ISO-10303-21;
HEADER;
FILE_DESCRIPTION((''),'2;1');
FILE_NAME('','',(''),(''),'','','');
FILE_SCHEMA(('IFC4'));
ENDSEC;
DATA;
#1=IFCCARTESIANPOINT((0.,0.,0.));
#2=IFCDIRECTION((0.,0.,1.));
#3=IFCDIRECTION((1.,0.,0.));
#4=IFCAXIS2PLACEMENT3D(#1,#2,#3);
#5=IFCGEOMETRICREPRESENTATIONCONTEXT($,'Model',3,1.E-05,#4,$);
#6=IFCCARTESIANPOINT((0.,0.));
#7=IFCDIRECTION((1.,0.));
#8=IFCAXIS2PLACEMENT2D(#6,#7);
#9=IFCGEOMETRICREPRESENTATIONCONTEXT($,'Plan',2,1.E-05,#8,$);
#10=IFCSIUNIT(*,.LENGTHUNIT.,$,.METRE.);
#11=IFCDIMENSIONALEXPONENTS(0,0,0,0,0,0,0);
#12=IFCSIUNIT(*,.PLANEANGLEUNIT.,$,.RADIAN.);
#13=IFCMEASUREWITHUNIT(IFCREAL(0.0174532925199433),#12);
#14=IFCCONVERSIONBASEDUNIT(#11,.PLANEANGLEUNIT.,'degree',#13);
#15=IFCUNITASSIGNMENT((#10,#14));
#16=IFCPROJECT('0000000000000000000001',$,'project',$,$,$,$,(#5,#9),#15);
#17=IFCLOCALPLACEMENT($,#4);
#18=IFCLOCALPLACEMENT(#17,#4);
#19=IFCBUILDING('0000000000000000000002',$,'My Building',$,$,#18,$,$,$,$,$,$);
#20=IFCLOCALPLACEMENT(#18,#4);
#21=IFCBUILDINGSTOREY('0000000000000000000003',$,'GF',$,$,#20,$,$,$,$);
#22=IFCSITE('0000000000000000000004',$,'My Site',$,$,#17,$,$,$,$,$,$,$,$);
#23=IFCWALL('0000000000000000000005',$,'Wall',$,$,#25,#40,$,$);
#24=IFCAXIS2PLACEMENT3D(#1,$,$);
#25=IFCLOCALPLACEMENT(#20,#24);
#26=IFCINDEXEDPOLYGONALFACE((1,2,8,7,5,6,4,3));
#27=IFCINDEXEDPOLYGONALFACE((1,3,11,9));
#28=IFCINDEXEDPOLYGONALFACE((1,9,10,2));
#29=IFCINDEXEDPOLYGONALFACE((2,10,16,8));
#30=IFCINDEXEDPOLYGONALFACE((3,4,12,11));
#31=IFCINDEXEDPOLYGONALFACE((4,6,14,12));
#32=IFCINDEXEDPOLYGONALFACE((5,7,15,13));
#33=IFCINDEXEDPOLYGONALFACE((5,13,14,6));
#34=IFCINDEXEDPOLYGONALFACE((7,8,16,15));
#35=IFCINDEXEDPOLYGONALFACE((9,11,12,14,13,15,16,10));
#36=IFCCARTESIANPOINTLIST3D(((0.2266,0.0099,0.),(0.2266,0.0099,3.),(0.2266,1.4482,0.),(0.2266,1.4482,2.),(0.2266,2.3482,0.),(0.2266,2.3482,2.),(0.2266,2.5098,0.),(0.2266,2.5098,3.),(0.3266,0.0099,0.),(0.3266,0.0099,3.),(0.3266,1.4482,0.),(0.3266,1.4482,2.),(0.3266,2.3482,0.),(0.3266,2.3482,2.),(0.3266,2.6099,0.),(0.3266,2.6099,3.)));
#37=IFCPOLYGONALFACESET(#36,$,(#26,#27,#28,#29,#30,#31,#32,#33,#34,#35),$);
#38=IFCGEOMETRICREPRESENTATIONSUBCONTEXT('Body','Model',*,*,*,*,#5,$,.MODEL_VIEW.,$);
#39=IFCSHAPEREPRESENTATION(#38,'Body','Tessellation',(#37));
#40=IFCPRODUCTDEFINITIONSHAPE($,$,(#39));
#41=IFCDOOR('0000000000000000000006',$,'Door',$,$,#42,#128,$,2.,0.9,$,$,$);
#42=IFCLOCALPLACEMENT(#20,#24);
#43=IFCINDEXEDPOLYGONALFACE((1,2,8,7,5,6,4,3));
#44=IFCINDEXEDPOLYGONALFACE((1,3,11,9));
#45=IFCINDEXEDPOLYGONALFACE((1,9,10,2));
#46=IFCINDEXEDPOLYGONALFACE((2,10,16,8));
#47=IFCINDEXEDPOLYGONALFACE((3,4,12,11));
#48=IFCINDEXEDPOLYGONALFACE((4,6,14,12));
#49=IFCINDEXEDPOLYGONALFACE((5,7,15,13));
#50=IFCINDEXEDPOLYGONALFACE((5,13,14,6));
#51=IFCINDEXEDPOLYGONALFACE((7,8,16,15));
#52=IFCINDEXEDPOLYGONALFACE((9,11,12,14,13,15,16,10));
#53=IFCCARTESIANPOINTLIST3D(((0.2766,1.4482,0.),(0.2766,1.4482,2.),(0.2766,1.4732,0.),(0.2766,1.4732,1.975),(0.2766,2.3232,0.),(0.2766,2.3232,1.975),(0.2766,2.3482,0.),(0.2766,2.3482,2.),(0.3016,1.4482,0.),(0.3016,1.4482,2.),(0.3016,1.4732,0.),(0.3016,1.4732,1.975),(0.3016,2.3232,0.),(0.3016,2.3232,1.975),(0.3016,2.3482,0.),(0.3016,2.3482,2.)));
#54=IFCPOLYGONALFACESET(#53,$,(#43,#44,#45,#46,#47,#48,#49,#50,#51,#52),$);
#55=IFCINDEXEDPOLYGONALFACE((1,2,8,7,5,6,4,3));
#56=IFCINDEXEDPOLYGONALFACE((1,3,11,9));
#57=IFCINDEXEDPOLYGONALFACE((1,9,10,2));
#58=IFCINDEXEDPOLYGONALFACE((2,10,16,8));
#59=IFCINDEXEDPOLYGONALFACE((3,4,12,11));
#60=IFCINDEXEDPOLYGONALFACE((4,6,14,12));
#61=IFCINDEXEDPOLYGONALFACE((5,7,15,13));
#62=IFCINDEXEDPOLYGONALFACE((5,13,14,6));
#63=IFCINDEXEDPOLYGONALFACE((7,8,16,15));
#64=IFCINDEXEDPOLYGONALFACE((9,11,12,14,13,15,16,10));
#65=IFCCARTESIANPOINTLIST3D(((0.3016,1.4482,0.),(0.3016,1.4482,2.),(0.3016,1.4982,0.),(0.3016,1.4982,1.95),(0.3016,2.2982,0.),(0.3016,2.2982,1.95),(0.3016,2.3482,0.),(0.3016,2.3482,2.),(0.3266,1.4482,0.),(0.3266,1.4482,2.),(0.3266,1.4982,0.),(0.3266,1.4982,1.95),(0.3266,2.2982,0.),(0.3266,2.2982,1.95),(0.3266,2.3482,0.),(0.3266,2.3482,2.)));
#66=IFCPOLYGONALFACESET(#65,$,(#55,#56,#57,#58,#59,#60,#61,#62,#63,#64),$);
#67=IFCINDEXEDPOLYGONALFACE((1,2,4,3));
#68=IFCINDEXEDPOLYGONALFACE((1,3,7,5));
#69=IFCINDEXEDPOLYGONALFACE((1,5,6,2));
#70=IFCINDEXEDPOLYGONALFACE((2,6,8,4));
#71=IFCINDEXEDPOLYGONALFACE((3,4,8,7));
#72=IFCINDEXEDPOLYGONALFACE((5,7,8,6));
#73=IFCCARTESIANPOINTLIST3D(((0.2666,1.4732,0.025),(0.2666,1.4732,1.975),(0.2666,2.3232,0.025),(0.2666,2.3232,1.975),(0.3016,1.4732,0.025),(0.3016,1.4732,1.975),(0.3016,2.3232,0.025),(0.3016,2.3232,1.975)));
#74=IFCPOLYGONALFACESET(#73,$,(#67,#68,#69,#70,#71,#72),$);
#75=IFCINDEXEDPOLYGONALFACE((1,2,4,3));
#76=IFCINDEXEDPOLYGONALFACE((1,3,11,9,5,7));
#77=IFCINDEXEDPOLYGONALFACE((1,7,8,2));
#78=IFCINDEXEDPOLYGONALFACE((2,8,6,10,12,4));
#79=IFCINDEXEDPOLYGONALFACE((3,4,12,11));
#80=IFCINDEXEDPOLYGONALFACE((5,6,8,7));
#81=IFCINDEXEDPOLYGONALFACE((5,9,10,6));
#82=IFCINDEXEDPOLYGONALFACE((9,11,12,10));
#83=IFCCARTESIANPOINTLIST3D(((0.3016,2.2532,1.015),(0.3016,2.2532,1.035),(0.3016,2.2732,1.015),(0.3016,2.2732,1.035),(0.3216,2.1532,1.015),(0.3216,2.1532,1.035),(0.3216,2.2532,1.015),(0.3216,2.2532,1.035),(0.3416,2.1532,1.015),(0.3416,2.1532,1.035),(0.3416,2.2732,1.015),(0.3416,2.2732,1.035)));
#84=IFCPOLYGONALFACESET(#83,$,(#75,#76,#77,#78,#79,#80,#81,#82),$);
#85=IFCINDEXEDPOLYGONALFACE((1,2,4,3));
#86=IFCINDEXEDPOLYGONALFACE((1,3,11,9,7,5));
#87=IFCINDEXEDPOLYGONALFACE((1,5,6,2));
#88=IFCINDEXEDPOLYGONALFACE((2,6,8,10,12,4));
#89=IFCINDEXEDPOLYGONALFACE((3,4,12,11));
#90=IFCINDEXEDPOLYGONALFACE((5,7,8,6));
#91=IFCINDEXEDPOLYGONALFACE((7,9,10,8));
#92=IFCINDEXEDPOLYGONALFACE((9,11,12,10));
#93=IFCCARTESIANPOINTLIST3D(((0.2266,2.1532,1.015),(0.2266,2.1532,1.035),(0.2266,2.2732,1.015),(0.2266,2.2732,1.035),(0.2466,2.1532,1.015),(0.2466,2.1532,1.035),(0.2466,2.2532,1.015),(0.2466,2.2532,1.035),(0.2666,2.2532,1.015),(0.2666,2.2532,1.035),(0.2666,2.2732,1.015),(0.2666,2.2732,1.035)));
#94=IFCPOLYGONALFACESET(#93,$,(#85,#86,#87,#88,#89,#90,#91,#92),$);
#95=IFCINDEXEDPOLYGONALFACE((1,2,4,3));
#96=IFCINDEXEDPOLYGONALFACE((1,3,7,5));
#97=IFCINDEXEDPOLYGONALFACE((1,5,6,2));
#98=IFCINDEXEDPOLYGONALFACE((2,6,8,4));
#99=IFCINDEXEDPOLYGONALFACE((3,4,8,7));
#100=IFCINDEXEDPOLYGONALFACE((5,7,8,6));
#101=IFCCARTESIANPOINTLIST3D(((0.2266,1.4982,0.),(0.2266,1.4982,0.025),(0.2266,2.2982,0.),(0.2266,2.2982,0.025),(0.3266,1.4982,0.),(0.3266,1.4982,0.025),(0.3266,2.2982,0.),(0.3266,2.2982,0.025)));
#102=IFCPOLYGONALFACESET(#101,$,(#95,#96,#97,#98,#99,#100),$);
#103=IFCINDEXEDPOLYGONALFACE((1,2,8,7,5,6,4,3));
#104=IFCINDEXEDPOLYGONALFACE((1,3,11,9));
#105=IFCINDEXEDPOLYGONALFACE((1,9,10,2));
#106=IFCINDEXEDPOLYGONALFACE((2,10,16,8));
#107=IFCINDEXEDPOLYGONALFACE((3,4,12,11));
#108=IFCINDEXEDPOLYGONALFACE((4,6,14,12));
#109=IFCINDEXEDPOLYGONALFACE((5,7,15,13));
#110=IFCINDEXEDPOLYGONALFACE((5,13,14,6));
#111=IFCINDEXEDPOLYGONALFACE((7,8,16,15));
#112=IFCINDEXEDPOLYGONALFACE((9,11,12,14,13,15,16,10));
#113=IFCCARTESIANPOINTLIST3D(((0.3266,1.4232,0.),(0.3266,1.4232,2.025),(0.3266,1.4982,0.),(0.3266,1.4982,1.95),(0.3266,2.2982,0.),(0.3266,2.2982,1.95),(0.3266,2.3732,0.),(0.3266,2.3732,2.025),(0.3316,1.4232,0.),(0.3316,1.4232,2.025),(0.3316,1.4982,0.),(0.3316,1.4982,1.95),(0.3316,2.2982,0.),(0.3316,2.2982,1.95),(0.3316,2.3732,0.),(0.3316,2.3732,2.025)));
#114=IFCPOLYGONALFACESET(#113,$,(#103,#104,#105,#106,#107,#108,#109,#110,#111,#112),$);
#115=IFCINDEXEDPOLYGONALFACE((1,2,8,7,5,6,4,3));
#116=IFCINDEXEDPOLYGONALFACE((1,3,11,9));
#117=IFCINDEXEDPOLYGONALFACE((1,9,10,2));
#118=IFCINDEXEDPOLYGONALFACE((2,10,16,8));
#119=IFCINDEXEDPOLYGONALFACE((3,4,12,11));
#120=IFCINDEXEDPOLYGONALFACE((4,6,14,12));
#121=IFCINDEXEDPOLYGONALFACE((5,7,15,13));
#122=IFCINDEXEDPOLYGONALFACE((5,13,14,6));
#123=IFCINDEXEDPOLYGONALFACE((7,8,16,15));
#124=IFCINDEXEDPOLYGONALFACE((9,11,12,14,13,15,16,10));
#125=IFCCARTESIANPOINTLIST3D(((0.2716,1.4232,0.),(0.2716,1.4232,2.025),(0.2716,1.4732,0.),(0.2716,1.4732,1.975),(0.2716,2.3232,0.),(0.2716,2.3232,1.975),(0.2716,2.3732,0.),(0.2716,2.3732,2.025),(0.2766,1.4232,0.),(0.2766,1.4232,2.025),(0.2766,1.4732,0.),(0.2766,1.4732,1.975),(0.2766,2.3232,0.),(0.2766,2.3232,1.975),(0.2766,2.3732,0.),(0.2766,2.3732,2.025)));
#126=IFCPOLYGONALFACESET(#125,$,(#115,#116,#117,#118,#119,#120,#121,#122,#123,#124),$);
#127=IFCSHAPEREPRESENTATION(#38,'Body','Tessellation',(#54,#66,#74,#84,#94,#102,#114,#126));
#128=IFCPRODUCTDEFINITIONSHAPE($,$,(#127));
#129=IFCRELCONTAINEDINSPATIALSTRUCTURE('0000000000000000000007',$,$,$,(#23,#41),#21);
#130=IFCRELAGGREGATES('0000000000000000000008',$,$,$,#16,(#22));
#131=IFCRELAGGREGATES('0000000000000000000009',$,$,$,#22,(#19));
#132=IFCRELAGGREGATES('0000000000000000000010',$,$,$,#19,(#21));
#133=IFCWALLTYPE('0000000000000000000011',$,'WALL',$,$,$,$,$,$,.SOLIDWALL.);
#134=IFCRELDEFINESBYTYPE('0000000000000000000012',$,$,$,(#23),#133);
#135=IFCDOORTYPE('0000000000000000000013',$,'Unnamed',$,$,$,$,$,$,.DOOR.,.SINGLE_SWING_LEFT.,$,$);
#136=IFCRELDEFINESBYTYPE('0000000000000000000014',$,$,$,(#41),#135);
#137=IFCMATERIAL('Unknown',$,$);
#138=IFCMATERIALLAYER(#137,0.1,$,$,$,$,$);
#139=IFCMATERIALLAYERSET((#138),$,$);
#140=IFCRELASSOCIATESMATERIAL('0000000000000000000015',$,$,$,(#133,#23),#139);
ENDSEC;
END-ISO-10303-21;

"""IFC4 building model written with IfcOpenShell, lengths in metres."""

from ifc_helpers import new_model, entity, si_unit, converted_unit, frame, origin_with_axes, origin_2d_with_axis, place, context, subcontext, project, spatial, line, indexed_curve, outline, extrude, shape, source, transform, mapped, material, layer, layer_set, layer_usage, type_object, type_shapes, element, fill, save


model = new_model("IFC4")

# Units and contexts
model_context = context("Model", 3, precision=1e-05, world=origin_with_axes())
plan_context = context("Plan", 2, precision=1e-05, world=origin_2d_with_axis())
body_context_1 = subcontext(model_context, "Body", "Model", "MODEL_VIEW")
body_context_2 = subcontext(plan_context, "Body", "Plan", "PLAN_VIEW")
ifc_project = project(units=[si_unit("LENGTHUNIT", "METRE"), converted_unit("PLANEANGLEUNIT", "degree", entity("IfcReal", 0.0174532925199433), si_unit("PLANEANGLEUNIT", "RADIAN"), dimensions=[0, 0, 0, 0, 0, 0, 0])], contexts=[model_context, plan_context])

# Site, building, storey
site_placement = place(None, origin_with_axes())
site = spatial("IfcSite", under=ifc_project, at=site_placement, Name="My Site")
building_placement = place(site_placement, origin_with_axes())
building = spatial("IfcBuilding", under=site, at=building_placement, Name="My Building")
storey_placement = place(building_placement, origin_with_axes())
storey = spatial("IfcBuildingStorey", under=building, at=storey_placement, Name="GF")

# Shared definitions
ifc_material_1 = material(Name="Unknown")

# Shared definitions
ifc_layer_1 = layer(ifc_material_1, 0.1)
ifc_layer_set_1 = layer_set([ifc_layer_1])
wall_type = type_object("IfcWallType", Name="WALL", PredefinedType="SOLIDWALL", material=ifc_layer_set_1)

# Wall, opening, door
ifc_layer_usage_1 = layer_usage(ifc_layer_set_1, "AXIS2", "POSITIVE", 0.0)
wall_1_placement = place(storey_placement, frame((0.3266, 0.0099, 0.0), z_axis=(0.0, 0.0, 1.0), x_axis=(0.0, 1.0, 0.0)))
wall_1 = element("IfcWall", 1, at=wall_1_placement, inside=storey, type_object=wall_type, material=ifc_layer_usage_1, Name="Wall", context=body_context_1, shape_type="SweptSolid", body=[
    extrude(outline(indexed_curve([(0.0, 0.0), (0.0, 0.1), (2.4999, 0.1), (2.6, 0.0)], segments=[line(1, 2, 3, 4, 1)])), origin_with_axes(), (0.0, 0.0, 1.0), 3.0),
])
shared_shape_1 = source(origin_with_axes(), body_context_1, "Body", "SweptSolid", [
    extrude(outline(indexed_curve([(0.0, 0.0), (0.9, 0.0), (0.9, 2.0), (0.0, 2.0)], segments=[line(1, 2, 3, 4, 1)])), frame((0.0, -0.6, 0.0), z_axis=(0.0, -1.0, 0.0), x_axis=(1.0, 0.0, 0.0)), (0.0, 0.0, -1.0), 1.2),
])
opening_1_placement = place(wall_1_placement, frame((1.4383, 0.0, 0.0), z_axis=(0.0, 0.0, 1.0), x_axis=(1.0, 0.0, 0.0)))
opening_1 = element("IfcOpeningElement", 2, at=opening_1_placement, cuts=wall_1, PredefinedType="OPENING", context=body_context_1, shape_type="MappedRepresentation", body=[
    mapped(shared_shape_1, transform((0.0, 0.0, 0.0), x_axis=(1.0, 0.0, 0.0), y_axis=(0.0, 1.0, 0.0), z_axis=(0.0, 0.0, 1.0), scale=1.0)),
])
door_type = type_object("IfcDoorType", Name="Unnamed", OperationType="SINGLE_SWING_LEFT", PredefinedType="DOOR")
shared_shape_2 = source(origin_with_axes(), body_context_1, "Body", "SweptSolid", [
    extrude(outline(indexed_curve([(0.0, 0.0), (0.0, 2.0), (0.9, 2.0), (0.9, 0.0), (0.875, 0.0), (0.875, 1.975), (0.025, 1.975), (0.025, 0.0)], segments=[line(1, 2, 3, 4, 5, 6, 7, 8, 1)])), frame((0.0, 0.025, 0.0), z_axis=(0.0, -1.0, 0.0), x_axis=(1.0, 0.0, 0.0)), (0.0, 0.0, -1.0), 0.025),
    extrude(outline(indexed_curve([(0.0, 0.0), (0.0, 2.0), (0.9, 2.0), (0.9, 0.0), (0.85, 0.0), (0.85, 1.95), (0.05, 1.95), (0.05, 0.0)], segments=[line(1, 2, 3, 4, 5, 6, 7, 8, 1)])), frame((0.0, 0.0, 0.0), z_axis=(0.0, -1.0, 0.0), x_axis=(1.0, 0.0, 0.0)), (0.0, 0.0, -1.0), 0.025),
    extrude(outline(indexed_curve([(0.0, 0.0), (0.85, 0.0), (0.85, 0.035), (0.0, 0.035)], segments=[line(1, 2, 3, 4, 1)])), frame((0.025, 0.025, 0.025), z_axis=(0.0, 0.0, 1.0), x_axis=(1.0, 0.0, 0.0)), (0.0, 0.0, 1.0), 1.95),
    extrude(outline(indexed_curve([(0.0, 0.0), (0.0, -0.04), (-0.12, -0.04), (-0.12, -0.02), (-0.02, -0.02), (-0.02, 0.0)], segments=[line(1, 2, 3, 4, 5, 6, 1)])), frame((0.825, 0.025, 1.015), z_axis=(0.0, 0.0, 1.0), x_axis=(1.0, 0.0, 0.0)), (0.0, 0.0, 1.0), 0.02),
    extrude(outline(indexed_curve([(0.0, 0.0), (0.0, 0.04), (-0.12, 0.04), (-0.12, 0.02), (-0.02, 0.02), (-0.02, 0.0)], segments=[line(1, 2, 3, 4, 5, 6, 1)])), frame((0.825, 0.06, 1.015), z_axis=(0.0, 0.0, 1.0), x_axis=(1.0, 0.0, 0.0)), (0.0, 0.0, 1.0), 0.02),
    extrude(outline(indexed_curve([(0.0, 0.0), (0.8, 0.0), (0.8, 0.1), (0.0, 0.1)], segments=[line(1, 2, 3, 4, 1)])), frame((0.05, 0.0, 0.0), z_axis=(0.0, 0.0, 1.0), x_axis=(1.0, 0.0, 0.0)), (0.0, 0.0, 1.0), 0.025),
    extrude(outline(indexed_curve([(0.0, 0.0), (0.0, 2.025), (0.95, 2.025), (0.95, 0.0), (0.875, 0.0), (0.875, 1.95), (0.075, 1.95), (0.075, 0.0)], segments=[line(1, 2, 3, 4, 5, 6, 7, 8, 1)])), frame((-0.025, -0.005, 0.0), z_axis=(0.0, -1.0, 0.0), x_axis=(1.0, 0.0, 0.0)), (0.0, 0.0, -1.0), 0.005),
    extrude(outline(indexed_curve([(0.0, 0.0), (0.0, 2.025), (0.95, 2.025), (0.95, 0.0), (0.9, 0.0), (0.9, 1.975), (0.05, 1.975), (0.05, 0.0)], segments=[line(1, 2, 3, 4, 5, 6, 7, 8, 1)])), frame((-0.025, 0.05, 0.0), z_axis=(0.0, -1.0, 0.0), x_axis=(1.0, 0.0, 0.0)), (0.0, 0.0, -1.0), 0.005),
])
shared_shape_3 = source(origin_with_axes(), body_context_2, "Body", "Curve2D", [
    entity("IfcIndexedPolyCurve", entity("IfcCartesianPointList2D", [[0.0, 0.0], [0.0, 0.05], [0.025, 0.05], [0.025, 0.025], [0.05, 0.025], [0.05, 0.0]]), [entity("IfcLineIndex", [1, 2, 3, 4, 5, 6, 1])]),
    entity("IfcIndexedPolyCurve", entity("IfcCartesianPointList2D", [[0.9, 0.0], [0.9, 0.05], [0.875, 0.05], [0.875, 0.025], [0.85, 0.025], [0.85, 0.0]]), [entity("IfcLineIndex", [1, 2, 3, 4, 5, 6, 1])]),
    entity("IfcTrimmedCurve", entity("IfcEllipse", entity("IfcAxis2Placement2D", entity("IfcCartesianPoint", [0.06, 0.05]), entity("IfcDirection", [1.0, 0.0])), 0.815, 0.85), [entity("IfcCartesianPoint", [0.875, 0.05])], [entity("IfcCartesianPoint", [0.06, 0.9])], True, "CARTESIAN"),
    entity("IfcIndexedPolyCurve", entity("IfcCartesianPointList2D", [[0.025, 0.05], [0.06, 0.05], [0.06, 0.9], [0.025, 0.9]]), [entity("IfcLineIndex", [1, 2, 3, 4, 1])]),
])
type_shapes(door_type, [shared_shape_2, shared_shape_3])
door_1_placement = place(opening_1_placement, frame((0.0, 0.0, 0.0), z_axis=(0.0, 0.0, 1.0), x_axis=(1.0, 0.0, 0.0)))
door_1 = element("IfcDoor", 3, at=door_1_placement, inside=storey, type_object=door_type, Name="Door", OverallHeight=2.0, OverallWidth=0.9, shapes=[
    shape(body_context_1, "Body", "MappedRepresentation", [mapped(shared_shape_2, transform((0.0, 0.0, 0.0), x_axis=(1.0, 0.0, 0.0), y_axis=(0.0, 1.0, 0.0), z_axis=(0.0, 0.0, 1.0), scale=1.0))]),
    shape(body_context_2, "Body", "MappedRepresentation", [mapped(shared_shape_3, transform((0.0, 0.0, 0.0), x_axis=(1.0, 0.0, 0.0), y_axis=(0.0, 1.0, 0.0), z_axis=(0.0, 0.0, 1.0), scale=1.0))]),
])
fill(opening_1, door_1)

save(model, "model.ifc")
